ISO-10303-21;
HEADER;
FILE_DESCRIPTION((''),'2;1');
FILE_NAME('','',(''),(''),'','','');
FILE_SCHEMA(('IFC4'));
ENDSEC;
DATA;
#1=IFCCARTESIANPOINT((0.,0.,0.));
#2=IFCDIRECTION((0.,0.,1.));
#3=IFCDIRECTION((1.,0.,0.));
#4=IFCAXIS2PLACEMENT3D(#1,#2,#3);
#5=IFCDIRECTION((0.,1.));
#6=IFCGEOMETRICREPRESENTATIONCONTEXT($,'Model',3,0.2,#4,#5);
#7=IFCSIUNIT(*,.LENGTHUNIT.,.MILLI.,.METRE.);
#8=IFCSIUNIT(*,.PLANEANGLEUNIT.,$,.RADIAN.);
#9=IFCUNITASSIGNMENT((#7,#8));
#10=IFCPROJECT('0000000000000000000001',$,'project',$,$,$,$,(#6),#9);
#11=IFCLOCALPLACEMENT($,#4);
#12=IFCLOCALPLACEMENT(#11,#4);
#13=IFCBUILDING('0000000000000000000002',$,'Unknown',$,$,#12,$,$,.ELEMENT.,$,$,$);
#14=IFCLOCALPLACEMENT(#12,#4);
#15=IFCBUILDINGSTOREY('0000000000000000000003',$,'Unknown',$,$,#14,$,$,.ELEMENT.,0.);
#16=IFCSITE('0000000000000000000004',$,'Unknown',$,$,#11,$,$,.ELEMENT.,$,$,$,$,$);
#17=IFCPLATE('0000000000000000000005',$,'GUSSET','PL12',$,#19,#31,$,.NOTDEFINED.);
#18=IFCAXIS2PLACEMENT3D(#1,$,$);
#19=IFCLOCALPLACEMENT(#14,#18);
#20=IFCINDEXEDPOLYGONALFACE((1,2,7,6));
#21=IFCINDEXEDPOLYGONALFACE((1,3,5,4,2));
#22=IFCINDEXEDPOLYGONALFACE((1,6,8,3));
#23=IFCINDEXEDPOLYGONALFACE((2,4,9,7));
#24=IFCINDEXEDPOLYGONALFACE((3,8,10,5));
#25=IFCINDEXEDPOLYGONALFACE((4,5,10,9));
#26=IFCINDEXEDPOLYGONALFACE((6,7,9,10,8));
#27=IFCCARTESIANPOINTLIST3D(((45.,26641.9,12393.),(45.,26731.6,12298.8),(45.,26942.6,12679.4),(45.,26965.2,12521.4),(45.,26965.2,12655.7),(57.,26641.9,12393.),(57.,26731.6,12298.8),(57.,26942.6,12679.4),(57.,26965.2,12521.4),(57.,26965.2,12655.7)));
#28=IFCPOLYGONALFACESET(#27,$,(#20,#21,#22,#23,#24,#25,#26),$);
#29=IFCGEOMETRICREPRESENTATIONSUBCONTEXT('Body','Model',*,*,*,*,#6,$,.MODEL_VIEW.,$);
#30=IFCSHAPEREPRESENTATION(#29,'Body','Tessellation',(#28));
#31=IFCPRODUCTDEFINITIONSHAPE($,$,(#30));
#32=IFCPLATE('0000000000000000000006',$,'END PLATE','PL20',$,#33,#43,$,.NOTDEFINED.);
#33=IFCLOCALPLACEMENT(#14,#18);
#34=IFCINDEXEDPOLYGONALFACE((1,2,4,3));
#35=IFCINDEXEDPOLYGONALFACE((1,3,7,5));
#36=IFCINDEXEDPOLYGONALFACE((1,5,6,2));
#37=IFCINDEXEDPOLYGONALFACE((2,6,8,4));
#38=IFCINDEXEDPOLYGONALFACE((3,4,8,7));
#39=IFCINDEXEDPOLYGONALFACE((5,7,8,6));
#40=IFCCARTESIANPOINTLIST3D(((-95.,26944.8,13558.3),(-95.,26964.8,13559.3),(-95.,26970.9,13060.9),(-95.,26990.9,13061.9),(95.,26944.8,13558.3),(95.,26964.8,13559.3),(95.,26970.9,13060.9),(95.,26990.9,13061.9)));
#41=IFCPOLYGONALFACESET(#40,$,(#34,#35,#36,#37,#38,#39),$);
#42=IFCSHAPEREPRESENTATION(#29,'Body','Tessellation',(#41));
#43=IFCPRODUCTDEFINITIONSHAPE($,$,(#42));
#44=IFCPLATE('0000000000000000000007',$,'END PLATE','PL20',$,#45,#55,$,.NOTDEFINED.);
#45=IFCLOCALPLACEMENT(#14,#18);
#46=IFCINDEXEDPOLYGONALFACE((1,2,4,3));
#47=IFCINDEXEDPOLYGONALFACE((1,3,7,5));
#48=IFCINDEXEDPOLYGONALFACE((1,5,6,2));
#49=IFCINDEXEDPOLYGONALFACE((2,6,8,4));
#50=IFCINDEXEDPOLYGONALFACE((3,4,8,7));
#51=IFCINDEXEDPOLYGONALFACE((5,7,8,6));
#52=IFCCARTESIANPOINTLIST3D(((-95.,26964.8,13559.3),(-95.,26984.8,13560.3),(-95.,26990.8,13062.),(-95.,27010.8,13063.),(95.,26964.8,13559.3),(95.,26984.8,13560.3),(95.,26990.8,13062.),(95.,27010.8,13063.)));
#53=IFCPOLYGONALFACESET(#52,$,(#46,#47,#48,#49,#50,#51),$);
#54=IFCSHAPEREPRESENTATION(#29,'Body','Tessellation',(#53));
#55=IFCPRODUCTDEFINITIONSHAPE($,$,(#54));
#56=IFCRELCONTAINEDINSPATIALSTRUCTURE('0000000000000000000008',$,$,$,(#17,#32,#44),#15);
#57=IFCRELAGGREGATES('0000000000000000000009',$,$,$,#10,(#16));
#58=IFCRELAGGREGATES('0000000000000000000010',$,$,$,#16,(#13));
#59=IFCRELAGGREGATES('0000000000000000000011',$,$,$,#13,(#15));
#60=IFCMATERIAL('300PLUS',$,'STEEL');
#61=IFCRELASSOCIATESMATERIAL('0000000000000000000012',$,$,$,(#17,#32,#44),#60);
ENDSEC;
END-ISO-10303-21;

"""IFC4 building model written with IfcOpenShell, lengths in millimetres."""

from ifc_helpers import new_model, si_unit, direction, frame, origin_with_axes, place, context, subcontext, project, spatial, line, indexed_curve, outline, extrude, material, element, save


model = new_model("IFC4")

# Units and contexts
model_context = context("Model", 3, precision=0.2, world=origin_with_axes(), true_north=direction((0.0, 1.0)))
body_context = subcontext(model_context, "Body", "Model", "MODEL_VIEW")
ifc_project = project(units=[si_unit("LENGTHUNIT", "METRE", prefix="MILLI"), si_unit("PLANEANGLEUNIT", "RADIAN")], contexts=[model_context])

# Site, building, storey
site_placement = place(None, origin_with_axes())
site = spatial("IfcSite", under=ifc_project, at=site_placement, Name="Unknown", CompositionType="ELEMENT")
building_placement = place(site_placement, origin_with_axes())
building = spatial("IfcBuilding", under=site, at=building_placement, Name="Unknown", CompositionType="ELEMENT")
storey_placement = place(building_placement, origin_with_axes())
storey = spatial("IfcBuildingStorey", under=building, at=storey_placement, Name="Unknown", CompositionType="ELEMENT", Elevation=0.0)

# Shared definitions
ifc_material_1 = material(Name="300PLUS", Category="STEEL")

# Plates
plate_1_placement = place(storey_placement, frame((51.0, 26965.2, 12655.7), z_axis=(1.0, 0.0, 0.0), x_axis=(0.0, -0.690113, 0.723702)))
element("IfcPlate", 1, at=plate_1_placement, inside=storey, material=ifc_material_1, Name="GUSSET", Description="PL12", PredefinedType="NOTDEFINED", context=body_context, shape_type="SolidModel", body=[
    extrude(outline(indexed_curve([(0.0, 0.0), (32.7, 0.0), (33.0, 415.3), (-97.1, 415.4), (-97.2, 92.7)], segments=[line(1, 2, 3, 4, 5, 1)])), frame((0.0, 0.0, 6.0), z_axis=(0.0, 0.0, 1.0), x_axis=(1.0, 0.0, 0.0)), (0.0, 0.0, -1.0), 12.0),
])
plate_2_placement = place(storey_placement, frame((95.0, 26980.9, 13061.4), z_axis=(0.0, 0.998626, 0.052401), x_axis=(-1.0, 0.0, 0.0)))
element("IfcPlate", 2, at=plate_2_placement, inside=storey, material=ifc_material_1, Name="END PLATE", Description="PL20", PredefinedType="NOTDEFINED", context=body_context, shape_type="SolidModel", body=[
    extrude(outline(indexed_curve([(0.0, 0.0), (190.0, 0.0), (190.0, 498.1), (0.0, 498.1)], segments=[line(1, 2, 3, 4, 1)])), frame((0.0, 0.0, 10.0), z_axis=(0.0, 0.0, 1.0), x_axis=(1.0, 0.0, 0.0)), (0.0, 0.0, -1.0), 20.0),
])
plate_3_placement = place(storey_placement, frame((95.0, 27000.8, 13062.5), z_axis=(0.0, 0.998636, 0.052211), x_axis=(-1.0, 0.0, 0.0)))
element("IfcPlate", 3, at=plate_3_placement, inside=storey, material=ifc_material_1, Name="END PLATE", Description="PL20", PredefinedType="NOTDEFINED", context=body_context, shape_type="SolidModel", body=[
    extrude(outline(indexed_curve([(0.0, 0.0), (190.0, 0.0), (190.0, 498.0), (0.0, 498.0)], segments=[line(1, 2, 3, 4, 1)])), frame((0.0, 0.0, 10.0), z_axis=(0.0, 0.0, 1.0), x_axis=(1.0, 0.0, 0.0)), (0.0, 0.0, -1.0), 20.0),
])

save(model, "model.ifc")
